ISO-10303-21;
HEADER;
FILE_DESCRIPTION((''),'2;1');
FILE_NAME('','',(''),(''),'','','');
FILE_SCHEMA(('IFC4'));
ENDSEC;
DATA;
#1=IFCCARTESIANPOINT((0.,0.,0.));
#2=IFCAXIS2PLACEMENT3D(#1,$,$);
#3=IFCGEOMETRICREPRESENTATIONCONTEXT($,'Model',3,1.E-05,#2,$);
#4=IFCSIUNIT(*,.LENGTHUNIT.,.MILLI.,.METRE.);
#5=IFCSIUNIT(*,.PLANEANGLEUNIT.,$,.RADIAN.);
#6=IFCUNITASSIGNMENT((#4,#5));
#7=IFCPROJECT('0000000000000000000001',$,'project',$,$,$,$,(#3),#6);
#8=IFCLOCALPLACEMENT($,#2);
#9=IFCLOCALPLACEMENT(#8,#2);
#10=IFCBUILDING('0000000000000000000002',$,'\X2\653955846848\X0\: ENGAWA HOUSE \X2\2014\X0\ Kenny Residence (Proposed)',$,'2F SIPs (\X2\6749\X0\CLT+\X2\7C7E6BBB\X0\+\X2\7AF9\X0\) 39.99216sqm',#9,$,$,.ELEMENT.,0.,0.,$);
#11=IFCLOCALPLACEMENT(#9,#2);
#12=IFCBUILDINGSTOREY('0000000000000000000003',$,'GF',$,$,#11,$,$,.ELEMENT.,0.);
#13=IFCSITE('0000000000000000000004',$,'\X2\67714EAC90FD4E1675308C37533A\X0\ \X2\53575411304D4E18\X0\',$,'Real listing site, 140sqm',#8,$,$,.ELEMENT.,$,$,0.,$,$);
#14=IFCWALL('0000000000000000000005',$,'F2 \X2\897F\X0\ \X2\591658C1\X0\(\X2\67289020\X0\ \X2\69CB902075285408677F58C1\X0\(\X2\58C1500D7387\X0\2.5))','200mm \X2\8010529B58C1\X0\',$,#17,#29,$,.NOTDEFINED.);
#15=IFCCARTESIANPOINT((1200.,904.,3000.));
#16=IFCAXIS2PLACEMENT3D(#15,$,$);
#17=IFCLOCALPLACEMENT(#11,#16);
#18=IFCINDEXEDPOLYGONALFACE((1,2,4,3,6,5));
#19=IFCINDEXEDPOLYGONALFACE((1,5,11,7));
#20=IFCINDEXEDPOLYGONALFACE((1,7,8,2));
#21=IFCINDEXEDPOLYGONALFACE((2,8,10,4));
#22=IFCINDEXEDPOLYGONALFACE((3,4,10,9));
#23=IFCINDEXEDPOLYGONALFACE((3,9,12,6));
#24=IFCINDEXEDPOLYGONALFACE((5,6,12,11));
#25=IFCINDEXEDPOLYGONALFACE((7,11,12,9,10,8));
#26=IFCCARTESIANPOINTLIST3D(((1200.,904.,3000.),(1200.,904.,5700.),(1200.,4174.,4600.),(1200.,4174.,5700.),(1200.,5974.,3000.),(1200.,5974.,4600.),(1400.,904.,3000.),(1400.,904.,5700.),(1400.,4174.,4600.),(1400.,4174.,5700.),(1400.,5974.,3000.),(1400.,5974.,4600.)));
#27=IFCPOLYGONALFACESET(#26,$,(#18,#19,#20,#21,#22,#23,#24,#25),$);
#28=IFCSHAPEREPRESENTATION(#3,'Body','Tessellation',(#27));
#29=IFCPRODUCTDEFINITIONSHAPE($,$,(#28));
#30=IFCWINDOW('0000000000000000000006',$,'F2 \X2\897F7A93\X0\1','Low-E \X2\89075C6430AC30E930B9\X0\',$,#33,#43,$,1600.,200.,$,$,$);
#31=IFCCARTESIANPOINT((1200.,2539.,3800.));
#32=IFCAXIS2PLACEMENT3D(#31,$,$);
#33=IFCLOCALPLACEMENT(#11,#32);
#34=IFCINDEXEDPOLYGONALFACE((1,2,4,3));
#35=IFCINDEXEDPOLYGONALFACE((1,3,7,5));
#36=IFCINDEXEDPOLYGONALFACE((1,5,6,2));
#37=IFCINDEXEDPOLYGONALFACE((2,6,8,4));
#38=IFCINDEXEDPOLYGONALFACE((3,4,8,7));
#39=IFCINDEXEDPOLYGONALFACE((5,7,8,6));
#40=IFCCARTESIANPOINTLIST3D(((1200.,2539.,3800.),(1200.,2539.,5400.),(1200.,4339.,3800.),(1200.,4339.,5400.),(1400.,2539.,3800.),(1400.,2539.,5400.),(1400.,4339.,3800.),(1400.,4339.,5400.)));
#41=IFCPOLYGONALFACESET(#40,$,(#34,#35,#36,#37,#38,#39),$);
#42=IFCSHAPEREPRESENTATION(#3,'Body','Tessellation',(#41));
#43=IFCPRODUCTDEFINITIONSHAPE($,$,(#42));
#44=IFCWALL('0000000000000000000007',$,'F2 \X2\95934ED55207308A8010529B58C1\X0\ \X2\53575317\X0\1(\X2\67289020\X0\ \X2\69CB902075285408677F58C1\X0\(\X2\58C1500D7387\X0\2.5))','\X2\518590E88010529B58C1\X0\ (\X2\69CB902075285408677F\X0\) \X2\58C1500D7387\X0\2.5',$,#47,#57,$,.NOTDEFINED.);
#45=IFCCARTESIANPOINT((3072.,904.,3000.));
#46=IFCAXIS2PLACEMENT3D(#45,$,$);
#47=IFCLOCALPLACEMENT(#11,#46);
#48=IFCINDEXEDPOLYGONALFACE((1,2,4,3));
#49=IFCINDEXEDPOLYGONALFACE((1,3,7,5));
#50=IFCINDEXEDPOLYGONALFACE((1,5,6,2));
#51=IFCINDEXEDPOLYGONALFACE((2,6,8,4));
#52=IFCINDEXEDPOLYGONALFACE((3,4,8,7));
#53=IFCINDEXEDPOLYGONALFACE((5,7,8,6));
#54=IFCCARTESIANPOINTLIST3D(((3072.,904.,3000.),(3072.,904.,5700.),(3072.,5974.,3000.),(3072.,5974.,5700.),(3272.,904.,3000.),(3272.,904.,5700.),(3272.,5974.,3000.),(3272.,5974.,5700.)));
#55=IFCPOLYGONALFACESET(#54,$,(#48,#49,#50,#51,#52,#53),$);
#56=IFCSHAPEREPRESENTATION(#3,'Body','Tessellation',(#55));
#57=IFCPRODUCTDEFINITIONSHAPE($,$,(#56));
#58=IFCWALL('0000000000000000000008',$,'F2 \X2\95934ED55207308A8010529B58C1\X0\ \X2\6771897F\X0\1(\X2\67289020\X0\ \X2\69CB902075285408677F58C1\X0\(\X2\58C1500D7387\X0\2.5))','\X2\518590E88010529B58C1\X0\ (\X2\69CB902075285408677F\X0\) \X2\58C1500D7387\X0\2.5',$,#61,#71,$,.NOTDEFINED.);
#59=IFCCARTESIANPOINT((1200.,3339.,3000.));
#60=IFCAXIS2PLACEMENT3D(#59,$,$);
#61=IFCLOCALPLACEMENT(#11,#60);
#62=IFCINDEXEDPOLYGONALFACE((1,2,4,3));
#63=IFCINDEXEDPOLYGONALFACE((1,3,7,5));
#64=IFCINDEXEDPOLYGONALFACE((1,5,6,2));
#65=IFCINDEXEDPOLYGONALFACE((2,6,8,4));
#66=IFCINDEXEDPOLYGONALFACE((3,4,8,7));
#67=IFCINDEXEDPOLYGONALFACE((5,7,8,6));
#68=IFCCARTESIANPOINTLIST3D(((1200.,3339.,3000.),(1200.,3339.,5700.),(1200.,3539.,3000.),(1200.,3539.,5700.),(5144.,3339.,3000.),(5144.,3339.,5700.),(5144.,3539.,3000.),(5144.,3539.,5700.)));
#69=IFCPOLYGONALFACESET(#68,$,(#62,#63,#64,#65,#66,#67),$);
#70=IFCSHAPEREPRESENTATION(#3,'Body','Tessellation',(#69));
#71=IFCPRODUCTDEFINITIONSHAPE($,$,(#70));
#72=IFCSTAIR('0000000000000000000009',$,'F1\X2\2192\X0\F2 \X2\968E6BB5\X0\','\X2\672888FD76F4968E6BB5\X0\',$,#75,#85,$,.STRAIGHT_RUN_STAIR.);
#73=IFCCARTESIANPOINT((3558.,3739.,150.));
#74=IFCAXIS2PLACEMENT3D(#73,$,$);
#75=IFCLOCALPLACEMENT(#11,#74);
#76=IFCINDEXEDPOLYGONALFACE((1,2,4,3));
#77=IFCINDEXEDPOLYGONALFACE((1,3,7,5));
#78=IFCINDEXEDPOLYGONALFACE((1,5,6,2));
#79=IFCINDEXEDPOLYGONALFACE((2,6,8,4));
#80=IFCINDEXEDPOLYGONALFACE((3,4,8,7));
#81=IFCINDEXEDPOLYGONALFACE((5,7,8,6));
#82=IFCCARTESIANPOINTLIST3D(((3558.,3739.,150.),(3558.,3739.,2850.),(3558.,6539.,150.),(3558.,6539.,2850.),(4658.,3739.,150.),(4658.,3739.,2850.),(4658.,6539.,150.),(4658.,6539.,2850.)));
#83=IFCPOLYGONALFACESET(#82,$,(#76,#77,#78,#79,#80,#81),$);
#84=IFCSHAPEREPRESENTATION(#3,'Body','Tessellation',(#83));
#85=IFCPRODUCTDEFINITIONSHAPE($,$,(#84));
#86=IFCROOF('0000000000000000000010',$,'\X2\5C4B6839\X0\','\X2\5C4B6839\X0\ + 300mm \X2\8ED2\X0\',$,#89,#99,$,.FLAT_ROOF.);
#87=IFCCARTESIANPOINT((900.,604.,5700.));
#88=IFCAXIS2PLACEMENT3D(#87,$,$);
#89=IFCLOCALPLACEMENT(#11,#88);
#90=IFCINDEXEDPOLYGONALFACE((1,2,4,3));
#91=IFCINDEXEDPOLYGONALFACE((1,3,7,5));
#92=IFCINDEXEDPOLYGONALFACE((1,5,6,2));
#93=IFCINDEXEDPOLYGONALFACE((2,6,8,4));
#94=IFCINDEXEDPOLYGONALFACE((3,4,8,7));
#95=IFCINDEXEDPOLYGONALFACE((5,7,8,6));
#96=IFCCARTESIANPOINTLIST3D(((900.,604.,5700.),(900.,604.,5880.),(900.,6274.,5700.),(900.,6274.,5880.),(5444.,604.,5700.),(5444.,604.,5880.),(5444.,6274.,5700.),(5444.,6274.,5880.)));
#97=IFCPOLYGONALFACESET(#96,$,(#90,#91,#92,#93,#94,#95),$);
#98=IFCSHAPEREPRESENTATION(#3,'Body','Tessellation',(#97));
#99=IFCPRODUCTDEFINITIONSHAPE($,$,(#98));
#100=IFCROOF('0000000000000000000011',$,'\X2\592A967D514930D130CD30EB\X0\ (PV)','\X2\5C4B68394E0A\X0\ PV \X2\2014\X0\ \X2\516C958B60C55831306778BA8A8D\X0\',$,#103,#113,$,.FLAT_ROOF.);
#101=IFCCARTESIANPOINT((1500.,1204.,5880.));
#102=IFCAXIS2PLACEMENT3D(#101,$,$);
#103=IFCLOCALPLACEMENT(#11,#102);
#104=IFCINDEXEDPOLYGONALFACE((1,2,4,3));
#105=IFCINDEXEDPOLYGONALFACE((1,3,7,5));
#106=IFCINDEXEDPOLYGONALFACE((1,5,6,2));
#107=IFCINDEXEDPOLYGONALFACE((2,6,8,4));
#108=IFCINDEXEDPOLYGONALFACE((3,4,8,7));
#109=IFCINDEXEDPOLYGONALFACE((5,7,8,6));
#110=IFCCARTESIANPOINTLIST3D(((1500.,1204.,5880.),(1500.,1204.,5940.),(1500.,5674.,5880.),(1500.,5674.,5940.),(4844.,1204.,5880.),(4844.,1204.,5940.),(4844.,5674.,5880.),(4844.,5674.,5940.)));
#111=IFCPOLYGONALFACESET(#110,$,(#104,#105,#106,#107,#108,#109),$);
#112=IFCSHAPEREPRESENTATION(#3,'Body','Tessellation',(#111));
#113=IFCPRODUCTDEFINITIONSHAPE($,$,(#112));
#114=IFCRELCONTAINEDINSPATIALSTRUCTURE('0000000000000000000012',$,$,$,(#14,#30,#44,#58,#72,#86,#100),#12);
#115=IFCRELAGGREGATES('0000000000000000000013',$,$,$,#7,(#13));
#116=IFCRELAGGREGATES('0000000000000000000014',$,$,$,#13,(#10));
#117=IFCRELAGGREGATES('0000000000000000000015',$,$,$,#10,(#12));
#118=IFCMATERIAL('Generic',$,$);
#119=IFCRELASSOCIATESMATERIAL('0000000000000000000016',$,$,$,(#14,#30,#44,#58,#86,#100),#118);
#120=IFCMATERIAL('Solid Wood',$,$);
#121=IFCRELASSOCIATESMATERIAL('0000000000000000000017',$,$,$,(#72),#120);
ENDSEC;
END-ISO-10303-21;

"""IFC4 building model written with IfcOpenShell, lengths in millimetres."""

from ifc_helpers import new_model, si_unit, frame, frame_2d, origin, place, context, project, spatial, rectangle, extrude, material, element, fill, save


model = new_model("IFC4")

# Units and contexts
model_context = context("Model", 3, precision=1e-05, world=origin())
ifc_project = project(units=[si_unit("LENGTHUNIT", "METRE", prefix="MILLI"), si_unit("PLANEANGLEUNIT", "RADIAN")], contexts=[model_context])

# Site, building, storey
site_placement = place(None, origin())
site = spatial("IfcSite", under=ifc_project, at=site_placement, Name="東京都世田谷区 南向き丘", ObjectType="Real listing site, 140sqm", CompositionType="ELEMENT", RefElevation=0.0)
building_placement = place(site_placement, origin())
building = spatial("IfcBuilding", under=site, at=building_placement, Name="改善案: ENGAWA HOUSE — Kenny Residence (Proposed)", ObjectType="2F SIPs (杉CLT+籾殻+竹) 39.99216sqm", CompositionType="ELEMENT", ElevationOfRefHeight=0.0, ElevationOfTerrain=0.0)
storey_placement = place(building_placement, origin())
storey = spatial("IfcBuildingStorey", under=building, at=storey_placement, Name="GF", CompositionType="ELEMENT", Elevation=0.0)

# Shared definitions
ifc_material_1 = material(Name="Generic")

# Shared definitions
ifc_material_2 = material(Name="Solid Wood")

# Wall, opening, window
wall_1_placement = place(storey_placement, frame((1200.0, 904.0, 3000.0)))
wall_1 = element("IfcWall", 1, at=wall_1_placement, inside=storey, material=ifc_material_1, Name="F2 西 外壁(木造 構造用合板壁(壁倍率2.5))", Description="200mm 耐力壁", PredefinedType="NOTDEFINED", context=model_context, shape_type="SweptSolid", body=[
    extrude(rectangle(XDim=200.0, YDim=5070.0, at=frame_2d((100.0, 2535.0))), frame((1200.0, 904.0, 3000.0)), (0.0, 0.0, 1.0), 2700.0),
])
opening_1_placement = place(storey_placement, frame((1200.0, 2539.0, 3800.0)))
opening_1 = element("IfcOpeningElement", 2, at=opening_1_placement, cuts=wall_1, PredefinedType="NOTDEFINED", context=model_context, shape_type="SweptSolid", body=[
    extrude(rectangle(XDim=200.0, YDim=1800.0, at=frame_2d((100.0, 900.0))), frame((1200.0, 2539.0, 3800.0)), (0.0, 0.0, 1.0), 1600.0),
])
window_1_placement = place(storey_placement, frame((1200.0, 2539.0, 3800.0)))
window_1 = element("IfcWindow", 3, at=window_1_placement, inside=storey, material=ifc_material_1, Name="F2 西窓1", Description="Low-E 複層ガラス", OverallHeight=1600.0, OverallWidth=200.0, context=model_context, shape_type="SweptSolid", body=[
    extrude(rectangle(XDim=200.0, YDim=1800.0, at=frame_2d((100.0, 900.0))), frame((1200.0, 2539.0, 3800.0)), (0.0, 0.0, 1.0), 1600.0),
])
fill(opening_1, window_1)

# Walls
wall_2_placement = place(storey_placement, frame((3072.0, 904.0, 3000.0)))
element("IfcWall", 4, at=wall_2_placement, inside=storey, material=ifc_material_1, Name="F2 間仕切り耐力壁 南北1(木造 構造用合板壁(壁倍率2.5))", Description="内部耐力壁 (構造用合板) 壁倍率2.5", PredefinedType="NOTDEFINED", context=model_context, shape_type="SweptSolid", body=[
    extrude(rectangle(XDim=200.0, YDim=5070.0, at=frame_2d((100.0, 2535.0))), frame((3072.0, 904.0, 3000.0)), (0.0, 0.0, 1.0), 2700.0),
])
wall_3_placement = place(storey_placement, frame((1200.0, 3339.0, 3000.0)))
element("IfcWall", 5, at=wall_3_placement, inside=storey, material=ifc_material_1, Name="F2 間仕切り耐力壁 東西1(木造 構造用合板壁(壁倍率2.5))", Description="内部耐力壁 (構造用合板) 壁倍率2.5", PredefinedType="NOTDEFINED", context=model_context, shape_type="SweptSolid", body=[
    extrude(rectangle(XDim=3944.0, YDim=200.0, at=frame_2d((1972.0, 100.0))), frame((1200.0, 3339.0, 3000.0)), (0.0, 0.0, 1.0), 2700.0),
])

# Stair
stair_placement = place(storey_placement, frame((3558.0, 3739.0, 150.0)))
element("IfcStair", 6, at=stair_placement, inside=storey, material=ifc_material_2, Name="F1→F2 階段", Description="木製直階段", PredefinedType="STRAIGHT_RUN_STAIR", context=model_context, shape_type="SweptSolid", body=[
    extrude(rectangle(XDim=1100.0, YDim=2800.0, at=frame_2d((550.0, 1400.0))), frame((3558.0, 3739.0, 150.0)), (0.0, 0.0, 1.0), 2700.0),
])

# Roofs
roof_1_placement = place(storey_placement, frame((900.0, 604.0, 5700.0)))
element("IfcRoof", 7, at=roof_1_placement, inside=storey, material=ifc_material_1, Name="屋根", Description="屋根 + 300mm 軒", PredefinedType="FLAT_ROOF", context=model_context, shape_type="SweptSolid", body=[
    extrude(rectangle(XDim=4544.0, YDim=5670.0, at=frame_2d((2272.0, 2835.0))), frame((900.0, 604.0, 5700.0)), (0.0, 0.0, 1.0), 180.0),
])
roof_2_placement = place(storey_placement, frame((1500.0, 1204.0, 5880.0)))
element("IfcRoof", 8, at=roof_2_placement, inside=storey, material=ifc_material_1, Name="太陽光パネル (PV)", Description="屋根上 PV — 公開情報で確認", PredefinedType="FLAT_ROOF", context=model_context, shape_type="SweptSolid", body=[
    extrude(rectangle(XDim=3344.0, YDim=4470.0, at=frame_2d((1672.0, 2235.0))), frame((1500.0, 1204.0, 5880.0)), (0.0, 0.0, 1.0), 60.0),
])

save(model, "model.ifc")
